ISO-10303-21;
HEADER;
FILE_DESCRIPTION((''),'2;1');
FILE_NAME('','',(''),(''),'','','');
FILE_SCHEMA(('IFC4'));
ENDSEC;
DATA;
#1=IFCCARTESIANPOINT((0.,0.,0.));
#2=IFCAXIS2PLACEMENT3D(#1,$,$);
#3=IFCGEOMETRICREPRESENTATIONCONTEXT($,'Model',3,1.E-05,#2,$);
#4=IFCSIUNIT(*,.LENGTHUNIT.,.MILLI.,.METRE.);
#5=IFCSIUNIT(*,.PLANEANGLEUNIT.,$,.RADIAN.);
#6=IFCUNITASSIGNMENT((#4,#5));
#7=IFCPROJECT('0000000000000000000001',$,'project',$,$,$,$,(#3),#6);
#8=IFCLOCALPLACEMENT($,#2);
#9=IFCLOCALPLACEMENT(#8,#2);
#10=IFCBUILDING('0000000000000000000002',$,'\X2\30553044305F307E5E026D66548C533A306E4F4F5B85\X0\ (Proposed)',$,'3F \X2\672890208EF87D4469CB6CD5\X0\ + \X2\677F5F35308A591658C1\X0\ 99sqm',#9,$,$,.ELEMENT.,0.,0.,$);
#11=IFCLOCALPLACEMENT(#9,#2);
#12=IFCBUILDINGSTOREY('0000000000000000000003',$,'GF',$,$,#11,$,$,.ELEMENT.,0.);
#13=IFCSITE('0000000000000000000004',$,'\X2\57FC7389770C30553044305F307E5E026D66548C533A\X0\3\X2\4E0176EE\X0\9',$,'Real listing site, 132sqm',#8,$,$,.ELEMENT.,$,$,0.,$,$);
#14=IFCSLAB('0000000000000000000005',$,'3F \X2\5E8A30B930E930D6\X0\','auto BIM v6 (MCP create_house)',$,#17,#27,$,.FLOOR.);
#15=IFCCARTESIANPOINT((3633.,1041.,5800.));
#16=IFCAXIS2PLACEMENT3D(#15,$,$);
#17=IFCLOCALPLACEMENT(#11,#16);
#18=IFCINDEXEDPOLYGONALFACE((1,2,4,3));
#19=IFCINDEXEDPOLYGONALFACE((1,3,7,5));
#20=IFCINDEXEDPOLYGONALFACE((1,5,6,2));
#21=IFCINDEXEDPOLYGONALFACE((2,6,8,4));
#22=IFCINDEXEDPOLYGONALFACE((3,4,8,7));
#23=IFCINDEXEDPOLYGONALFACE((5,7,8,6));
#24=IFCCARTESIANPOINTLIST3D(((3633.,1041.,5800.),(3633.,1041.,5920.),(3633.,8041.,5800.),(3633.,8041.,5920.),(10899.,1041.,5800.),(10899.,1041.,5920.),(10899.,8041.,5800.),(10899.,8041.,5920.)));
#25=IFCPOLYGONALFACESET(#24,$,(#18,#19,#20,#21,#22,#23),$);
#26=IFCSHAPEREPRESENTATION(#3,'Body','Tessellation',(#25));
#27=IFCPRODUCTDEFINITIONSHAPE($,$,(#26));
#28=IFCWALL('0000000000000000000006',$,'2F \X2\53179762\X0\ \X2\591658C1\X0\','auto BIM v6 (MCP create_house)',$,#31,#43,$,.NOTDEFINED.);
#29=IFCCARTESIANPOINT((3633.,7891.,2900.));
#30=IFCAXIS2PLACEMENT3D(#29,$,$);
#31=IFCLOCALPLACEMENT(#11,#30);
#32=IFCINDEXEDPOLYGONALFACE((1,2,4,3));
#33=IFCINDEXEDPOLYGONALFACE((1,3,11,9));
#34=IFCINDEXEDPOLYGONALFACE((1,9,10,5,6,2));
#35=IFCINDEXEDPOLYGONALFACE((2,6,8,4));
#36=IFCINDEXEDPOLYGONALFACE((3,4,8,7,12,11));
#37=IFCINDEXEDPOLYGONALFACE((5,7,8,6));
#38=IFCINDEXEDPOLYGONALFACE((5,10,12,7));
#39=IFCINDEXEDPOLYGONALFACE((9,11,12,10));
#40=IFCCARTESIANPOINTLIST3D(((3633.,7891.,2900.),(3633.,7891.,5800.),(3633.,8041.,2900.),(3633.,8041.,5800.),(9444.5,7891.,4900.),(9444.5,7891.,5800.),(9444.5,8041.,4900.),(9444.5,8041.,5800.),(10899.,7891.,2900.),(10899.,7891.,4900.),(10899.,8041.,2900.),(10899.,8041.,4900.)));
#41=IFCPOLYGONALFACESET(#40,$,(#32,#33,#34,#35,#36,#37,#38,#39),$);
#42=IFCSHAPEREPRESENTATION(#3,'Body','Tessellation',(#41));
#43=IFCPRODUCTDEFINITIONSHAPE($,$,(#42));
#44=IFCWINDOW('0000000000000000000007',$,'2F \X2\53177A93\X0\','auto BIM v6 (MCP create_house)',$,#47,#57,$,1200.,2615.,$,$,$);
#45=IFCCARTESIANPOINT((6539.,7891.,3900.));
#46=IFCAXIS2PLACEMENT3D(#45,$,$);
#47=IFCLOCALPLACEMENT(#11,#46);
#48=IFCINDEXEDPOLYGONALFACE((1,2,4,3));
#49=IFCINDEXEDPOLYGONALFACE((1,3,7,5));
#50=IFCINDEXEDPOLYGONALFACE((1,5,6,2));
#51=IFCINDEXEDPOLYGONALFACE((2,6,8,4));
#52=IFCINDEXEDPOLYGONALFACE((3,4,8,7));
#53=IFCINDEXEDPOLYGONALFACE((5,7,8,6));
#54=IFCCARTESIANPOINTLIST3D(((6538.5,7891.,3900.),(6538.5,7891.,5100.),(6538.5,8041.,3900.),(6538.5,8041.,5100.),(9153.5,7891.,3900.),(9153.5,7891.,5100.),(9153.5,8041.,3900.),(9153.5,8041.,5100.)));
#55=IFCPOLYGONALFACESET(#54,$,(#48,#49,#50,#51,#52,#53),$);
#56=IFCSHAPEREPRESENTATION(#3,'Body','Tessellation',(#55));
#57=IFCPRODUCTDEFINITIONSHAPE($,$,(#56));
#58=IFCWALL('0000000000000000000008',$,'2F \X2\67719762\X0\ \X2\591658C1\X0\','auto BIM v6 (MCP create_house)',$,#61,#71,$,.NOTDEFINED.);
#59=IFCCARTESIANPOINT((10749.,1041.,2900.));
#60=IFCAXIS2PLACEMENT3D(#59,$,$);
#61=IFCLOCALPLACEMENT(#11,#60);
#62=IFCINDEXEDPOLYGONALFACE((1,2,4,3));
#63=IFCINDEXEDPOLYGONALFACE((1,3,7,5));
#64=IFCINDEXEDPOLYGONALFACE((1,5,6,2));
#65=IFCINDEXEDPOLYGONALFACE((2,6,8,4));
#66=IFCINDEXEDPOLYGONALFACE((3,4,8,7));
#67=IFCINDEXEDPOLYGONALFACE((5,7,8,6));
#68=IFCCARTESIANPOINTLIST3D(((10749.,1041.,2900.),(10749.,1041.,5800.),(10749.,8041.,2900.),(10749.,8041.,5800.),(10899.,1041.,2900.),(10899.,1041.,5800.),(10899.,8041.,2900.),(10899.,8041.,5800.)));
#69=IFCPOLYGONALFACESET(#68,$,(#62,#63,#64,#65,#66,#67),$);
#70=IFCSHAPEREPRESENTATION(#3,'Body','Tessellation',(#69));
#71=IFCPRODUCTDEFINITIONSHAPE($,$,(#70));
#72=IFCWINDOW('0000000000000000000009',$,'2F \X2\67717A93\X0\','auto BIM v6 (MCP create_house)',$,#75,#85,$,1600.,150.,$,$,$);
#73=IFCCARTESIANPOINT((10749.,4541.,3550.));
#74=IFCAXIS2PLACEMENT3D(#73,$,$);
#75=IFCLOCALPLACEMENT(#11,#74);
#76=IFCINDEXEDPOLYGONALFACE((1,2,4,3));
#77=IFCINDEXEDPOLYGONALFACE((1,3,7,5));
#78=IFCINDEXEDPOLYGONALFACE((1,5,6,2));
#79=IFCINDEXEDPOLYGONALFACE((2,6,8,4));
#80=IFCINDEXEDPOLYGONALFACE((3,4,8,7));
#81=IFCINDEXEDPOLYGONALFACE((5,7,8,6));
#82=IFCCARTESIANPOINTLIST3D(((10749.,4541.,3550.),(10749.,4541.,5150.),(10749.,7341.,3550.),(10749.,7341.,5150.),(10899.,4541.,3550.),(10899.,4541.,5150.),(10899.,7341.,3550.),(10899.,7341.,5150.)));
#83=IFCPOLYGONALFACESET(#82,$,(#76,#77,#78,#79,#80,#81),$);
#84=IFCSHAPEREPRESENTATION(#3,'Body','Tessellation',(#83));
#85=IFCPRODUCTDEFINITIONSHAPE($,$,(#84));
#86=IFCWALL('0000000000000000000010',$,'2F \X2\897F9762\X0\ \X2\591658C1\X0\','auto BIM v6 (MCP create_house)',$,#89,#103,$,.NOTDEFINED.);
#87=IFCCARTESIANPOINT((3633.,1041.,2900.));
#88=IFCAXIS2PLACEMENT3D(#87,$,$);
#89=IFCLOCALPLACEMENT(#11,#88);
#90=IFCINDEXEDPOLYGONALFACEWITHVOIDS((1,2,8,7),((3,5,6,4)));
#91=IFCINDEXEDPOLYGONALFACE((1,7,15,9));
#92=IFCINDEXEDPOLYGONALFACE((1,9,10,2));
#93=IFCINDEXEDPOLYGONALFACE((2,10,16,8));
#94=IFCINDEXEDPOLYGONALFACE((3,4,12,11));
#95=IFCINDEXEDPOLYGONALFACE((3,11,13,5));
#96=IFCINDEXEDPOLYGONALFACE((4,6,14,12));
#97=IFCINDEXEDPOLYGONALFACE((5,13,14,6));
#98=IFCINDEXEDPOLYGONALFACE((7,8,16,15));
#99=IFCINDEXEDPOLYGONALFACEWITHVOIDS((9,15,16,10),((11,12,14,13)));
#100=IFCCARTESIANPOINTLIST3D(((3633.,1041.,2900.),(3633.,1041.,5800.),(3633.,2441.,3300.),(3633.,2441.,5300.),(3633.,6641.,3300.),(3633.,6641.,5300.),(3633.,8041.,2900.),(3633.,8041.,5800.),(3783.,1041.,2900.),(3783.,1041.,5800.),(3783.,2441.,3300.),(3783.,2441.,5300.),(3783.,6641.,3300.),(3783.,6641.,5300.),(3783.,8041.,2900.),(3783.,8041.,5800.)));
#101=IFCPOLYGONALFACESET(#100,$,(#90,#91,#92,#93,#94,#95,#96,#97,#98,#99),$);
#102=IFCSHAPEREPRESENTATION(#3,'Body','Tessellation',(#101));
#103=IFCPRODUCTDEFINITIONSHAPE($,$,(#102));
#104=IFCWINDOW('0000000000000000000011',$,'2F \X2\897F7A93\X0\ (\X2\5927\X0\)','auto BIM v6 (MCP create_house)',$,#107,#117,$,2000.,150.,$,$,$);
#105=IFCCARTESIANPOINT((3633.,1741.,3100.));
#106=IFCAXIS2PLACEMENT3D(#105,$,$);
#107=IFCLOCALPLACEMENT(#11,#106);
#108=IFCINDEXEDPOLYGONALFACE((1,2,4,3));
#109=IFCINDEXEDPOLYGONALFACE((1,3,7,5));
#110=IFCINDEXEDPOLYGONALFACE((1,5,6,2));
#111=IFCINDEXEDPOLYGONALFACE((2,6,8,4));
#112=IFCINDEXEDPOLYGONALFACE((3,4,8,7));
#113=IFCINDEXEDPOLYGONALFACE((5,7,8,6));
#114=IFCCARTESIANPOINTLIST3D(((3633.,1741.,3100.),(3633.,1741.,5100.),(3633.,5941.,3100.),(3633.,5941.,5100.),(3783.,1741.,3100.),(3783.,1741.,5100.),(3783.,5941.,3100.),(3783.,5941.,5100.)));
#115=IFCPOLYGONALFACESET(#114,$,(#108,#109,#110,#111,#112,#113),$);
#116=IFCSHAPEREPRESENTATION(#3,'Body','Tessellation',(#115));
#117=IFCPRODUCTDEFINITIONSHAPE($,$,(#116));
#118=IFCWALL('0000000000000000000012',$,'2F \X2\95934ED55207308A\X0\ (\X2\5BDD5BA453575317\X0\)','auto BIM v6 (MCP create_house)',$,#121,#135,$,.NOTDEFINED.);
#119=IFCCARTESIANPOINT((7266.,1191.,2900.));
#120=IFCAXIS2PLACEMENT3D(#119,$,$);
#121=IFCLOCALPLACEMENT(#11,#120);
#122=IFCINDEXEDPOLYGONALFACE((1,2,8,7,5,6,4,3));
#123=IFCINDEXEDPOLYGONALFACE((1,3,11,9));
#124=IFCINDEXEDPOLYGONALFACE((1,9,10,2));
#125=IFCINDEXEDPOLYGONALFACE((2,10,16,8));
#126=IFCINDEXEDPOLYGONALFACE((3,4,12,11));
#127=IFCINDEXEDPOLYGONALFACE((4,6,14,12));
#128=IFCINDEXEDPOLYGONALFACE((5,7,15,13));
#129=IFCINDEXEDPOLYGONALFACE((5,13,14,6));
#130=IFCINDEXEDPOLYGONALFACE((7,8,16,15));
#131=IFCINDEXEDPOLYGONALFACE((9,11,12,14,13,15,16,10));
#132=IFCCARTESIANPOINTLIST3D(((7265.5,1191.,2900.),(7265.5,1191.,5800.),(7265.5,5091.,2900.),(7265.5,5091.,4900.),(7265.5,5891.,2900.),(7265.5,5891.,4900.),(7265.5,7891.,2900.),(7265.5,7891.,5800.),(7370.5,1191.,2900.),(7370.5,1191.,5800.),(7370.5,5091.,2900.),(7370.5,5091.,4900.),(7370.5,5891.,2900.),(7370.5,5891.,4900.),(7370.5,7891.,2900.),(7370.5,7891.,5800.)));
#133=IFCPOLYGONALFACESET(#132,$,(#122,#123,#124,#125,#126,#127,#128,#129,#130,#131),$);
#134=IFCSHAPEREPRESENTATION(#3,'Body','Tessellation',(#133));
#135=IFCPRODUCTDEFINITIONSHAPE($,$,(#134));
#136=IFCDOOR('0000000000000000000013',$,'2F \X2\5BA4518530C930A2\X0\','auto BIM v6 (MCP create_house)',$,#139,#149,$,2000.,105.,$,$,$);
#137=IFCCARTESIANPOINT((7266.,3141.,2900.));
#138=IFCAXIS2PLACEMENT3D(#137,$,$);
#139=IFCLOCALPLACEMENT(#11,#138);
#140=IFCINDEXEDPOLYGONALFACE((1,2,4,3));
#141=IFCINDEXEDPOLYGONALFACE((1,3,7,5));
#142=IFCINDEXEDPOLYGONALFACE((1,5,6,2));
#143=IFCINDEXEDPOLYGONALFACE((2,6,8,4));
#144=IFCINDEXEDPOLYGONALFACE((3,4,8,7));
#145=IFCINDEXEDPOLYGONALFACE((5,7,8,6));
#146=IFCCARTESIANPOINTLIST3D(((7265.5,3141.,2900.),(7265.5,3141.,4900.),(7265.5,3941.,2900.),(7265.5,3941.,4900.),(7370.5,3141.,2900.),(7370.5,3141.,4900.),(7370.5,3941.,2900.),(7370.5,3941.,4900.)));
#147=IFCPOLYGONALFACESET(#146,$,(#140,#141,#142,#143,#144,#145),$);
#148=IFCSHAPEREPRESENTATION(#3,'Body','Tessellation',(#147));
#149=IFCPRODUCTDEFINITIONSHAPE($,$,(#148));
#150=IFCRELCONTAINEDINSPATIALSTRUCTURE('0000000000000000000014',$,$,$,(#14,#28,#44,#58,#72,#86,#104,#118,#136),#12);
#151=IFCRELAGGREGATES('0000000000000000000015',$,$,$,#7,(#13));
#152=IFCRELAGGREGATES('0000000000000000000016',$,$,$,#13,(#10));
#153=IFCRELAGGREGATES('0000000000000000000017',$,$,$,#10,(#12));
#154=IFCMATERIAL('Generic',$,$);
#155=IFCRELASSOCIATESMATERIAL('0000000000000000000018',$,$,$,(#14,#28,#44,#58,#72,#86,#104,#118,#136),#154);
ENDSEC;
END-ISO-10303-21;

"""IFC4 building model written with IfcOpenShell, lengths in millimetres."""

from ifc_helpers import new_model, si_unit, frame, frame_2d, origin, place, context, project, spatial, rectangle, extrude, material, element, fill, save


model = new_model("IFC4")

# Units and contexts
model_context = context("Model", 3, precision=1e-05, world=origin())
ifc_project = project(units=[si_unit("LENGTHUNIT", "METRE", prefix="MILLI"), si_unit("PLANEANGLEUNIT", "RADIAN")], contexts=[model_context])

# Site, building, storey
site_placement = place(None, origin())
site = spatial("IfcSite", under=ifc_project, at=site_placement, Name="埼玉県さいたま市浦和区3丁目9", ObjectType="Real listing site, 132sqm", CompositionType="ELEMENT", RefElevation=0.0)
building_placement = place(site_placement, origin())
building = spatial("IfcBuilding", under=site, at=building_placement, Name="さいたま市浦和区の住宅 (Proposed)", ObjectType="3F 木造軸組構法 + 板張り外壁 99sqm", CompositionType="ELEMENT", ElevationOfRefHeight=0.0, ElevationOfTerrain=0.0)
storey_placement = place(building_placement, origin())
storey = spatial("IfcBuildingStorey", under=building, at=storey_placement, Name="GF", CompositionType="ELEMENT", Elevation=0.0)

# Slab
ifc_material = material(Name="Generic")
slab_placement = place(storey_placement, frame((3633.0, 1041.0, 5800.0)))
element("IfcSlab", 1, at=slab_placement, inside=storey, material=ifc_material, Name="3F 床スラブ", Description="auto BIM v6 (MCP create_house)", PredefinedType="FLOOR", context=model_context, shape_type="SweptSolid", body=[
    extrude(rectangle(XDim=7266.0, YDim=7000.0, at=frame_2d((3633.0, 3500.0))), frame((3633.0, 1041.0, 5800.0)), (0.0, 0.0, 1.0), 120.0),
])

# Walls, openings, windows
wall_1_placement = place(storey_placement, frame((3633.0, 7891.0, 2900.0)))
wall_1 = element("IfcWall", 2, at=wall_1_placement, inside=storey, material=ifc_material, Name="2F 北面 外壁", Description="auto BIM v6 (MCP create_house)", PredefinedType="NOTDEFINED", context=model_context, shape_type="SweptSolid", body=[
    extrude(rectangle(XDim=7266.0, YDim=150.0, at=frame_2d((3633.0, 75.0))), frame((3633.0, 7891.0, 2900.0)), (0.0, 0.0, 1.0), 2900.0),
])
opening_1_placement = place(storey_placement, frame((6539.0, 7891.0, 3900.0)))
opening_1 = element("IfcOpeningElement", 3, at=opening_1_placement, cuts=wall_1, PredefinedType="NOTDEFINED", context=model_context, shape_type="SweptSolid", body=[
    extrude(rectangle(XDim=2615.0, YDim=150.0, at=frame_2d((1307.0, 75.0))), frame((6539.0, 7891.0, 3900.0)), (0.0, 0.0, 1.0), 1200.0),
])
window_1_placement = place(storey_placement, frame((6539.0, 7891.0, 3900.0)))
window_1 = element("IfcWindow", 4, at=window_1_placement, inside=storey, material=ifc_material, Name="2F 北窓", Description="auto BIM v6 (MCP create_house)", OverallHeight=1200.0, OverallWidth=2615.0, context=model_context, shape_type="SweptSolid", body=[
    extrude(rectangle(XDim=2615.0, YDim=150.0, at=frame_2d((1307.0, 75.0))), frame((6539.0, 7891.0, 3900.0)), (0.0, 0.0, 1.0), 1200.0),
])
fill(opening_1, window_1)
wall_2_placement = place(storey_placement, frame((10749.0, 1041.0, 2900.0)))
wall_2 = element("IfcWall", 5, at=wall_2_placement, inside=storey, material=ifc_material, Name="2F 東面 外壁", Description="auto BIM v6 (MCP create_house)", PredefinedType="NOTDEFINED", context=model_context, shape_type="SweptSolid", body=[
    extrude(rectangle(XDim=150.0, YDim=7000.0, at=frame_2d((75.0, 3500.0))), frame((10749.0, 1041.0, 2900.0)), (0.0, 0.0, 1.0), 2900.0),
])
opening_2_placement = place(storey_placement, frame((10749.0, 4541.0, 3550.0)))
opening_2 = element("IfcOpeningElement", 6, at=opening_2_placement, cuts=wall_2, PredefinedType="NOTDEFINED", context=model_context, shape_type="SweptSolid", body=[
    extrude(rectangle(XDim=150.0, YDim=2800.0, at=frame_2d((75.0, 1400.0))), frame((10749.0, 4541.0, 3550.0)), (0.0, 0.0, 1.0), 1600.0),
])
window_2_placement = place(storey_placement, frame((10749.0, 4541.0, 3550.0)))
window_2 = element("IfcWindow", 7, at=window_2_placement, inside=storey, material=ifc_material, Name="2F 東窓", Description="auto BIM v6 (MCP create_house)", OverallHeight=1600.0, OverallWidth=150.0, context=model_context, shape_type="SweptSolid", body=[
    extrude(rectangle(XDim=150.0, YDim=2800.0, at=frame_2d((75.0, 1400.0))), frame((10749.0, 4541.0, 3550.0)), (0.0, 0.0, 1.0), 1600.0),
])
fill(opening_2, window_2)
wall_3_placement = place(storey_placement, frame((3633.0, 1041.0, 2900.0)))
wall_3 = element("IfcWall", 8, at=wall_3_placement, inside=storey, material=ifc_material, Name="2F 西面 外壁", Description="auto BIM v6 (MCP create_house)", PredefinedType="NOTDEFINED", context=model_context, shape_type="SweptSolid", body=[
    extrude(rectangle(XDim=150.0, YDim=7000.0, at=frame_2d((75.0, 3500.0))), frame((3633.0, 1041.0, 2900.0)), (0.0, 0.0, 1.0), 2900.0),
])
opening_3_placement = place(storey_placement, frame((3633.0, 1741.0, 3100.0)))
opening_3 = element("IfcOpeningElement", 9, at=opening_3_placement, cuts=wall_3, PredefinedType="NOTDEFINED", context=model_context, shape_type="SweptSolid", body=[
    extrude(rectangle(XDim=150.0, YDim=4200.0, at=frame_2d((75.0, 2100.0))), frame((3633.0, 1741.0, 3100.0)), (0.0, 0.0, 1.0), 2000.0),
])
window_3_placement = place(storey_placement, frame((3633.0, 1741.0, 3100.0)))
window_3 = element("IfcWindow", 10, at=window_3_placement, inside=storey, material=ifc_material, Name="2F 西窓 (大)", Description="auto BIM v6 (MCP create_house)", OverallHeight=2000.0, OverallWidth=150.0, context=model_context, shape_type="SweptSolid", body=[
    extrude(rectangle(XDim=150.0, YDim=4200.0, at=frame_2d((75.0, 2100.0))), frame((3633.0, 1741.0, 3100.0)), (0.0, 0.0, 1.0), 2000.0),
])
fill(opening_3, window_3)

# Wall, opening, door
wall_4_placement = place(storey_placement, frame((7266.0, 1191.0, 2900.0)))
wall_4 = element("IfcWall", 11, at=wall_4_placement, inside=storey, material=ifc_material, Name="2F 間仕切り (寝室南北)", Description="auto BIM v6 (MCP create_house)", PredefinedType="NOTDEFINED", context=model_context, shape_type="SweptSolid", body=[
    extrude(rectangle(XDim=105.0, YDim=6700.0, at=frame_2d((52.0, 3350.0))), frame((7266.0, 1191.0, 2900.0)), (0.0, 0.0, 1.0), 2900.0),
])
opening_4_placement = place(storey_placement, frame((7266.0, 3141.0, 2900.0)))
opening_4 = element("IfcOpeningElement", 12, at=opening_4_placement, cuts=wall_4, PredefinedType="NOTDEFINED", context=model_context, shape_type="SweptSolid", body=[
    extrude(rectangle(XDim=105.0, YDim=800.0, at=frame_2d((52.0, 400.0))), frame((7266.0, 3141.0, 2900.0)), (0.0, 0.0, 1.0), 2000.0),
])
door_1_placement = place(storey_placement, frame((7266.0, 3141.0, 2900.0)))
door_1 = element("IfcDoor", 13, at=door_1_placement, inside=storey, material=ifc_material, Name="2F 室内ドア", Description="auto BIM v6 (MCP create_house)", OverallHeight=2000.0, OverallWidth=105.0, context=model_context, shape_type="SweptSolid", body=[
    extrude(rectangle(XDim=105.0, YDim=800.0, at=frame_2d((52.0, 400.0))), frame((7266.0, 3141.0, 2900.0)), (0.0, 0.0, 1.0), 2000.0),
])
fill(opening_4, door_1)

save(model, "model.ifc")
